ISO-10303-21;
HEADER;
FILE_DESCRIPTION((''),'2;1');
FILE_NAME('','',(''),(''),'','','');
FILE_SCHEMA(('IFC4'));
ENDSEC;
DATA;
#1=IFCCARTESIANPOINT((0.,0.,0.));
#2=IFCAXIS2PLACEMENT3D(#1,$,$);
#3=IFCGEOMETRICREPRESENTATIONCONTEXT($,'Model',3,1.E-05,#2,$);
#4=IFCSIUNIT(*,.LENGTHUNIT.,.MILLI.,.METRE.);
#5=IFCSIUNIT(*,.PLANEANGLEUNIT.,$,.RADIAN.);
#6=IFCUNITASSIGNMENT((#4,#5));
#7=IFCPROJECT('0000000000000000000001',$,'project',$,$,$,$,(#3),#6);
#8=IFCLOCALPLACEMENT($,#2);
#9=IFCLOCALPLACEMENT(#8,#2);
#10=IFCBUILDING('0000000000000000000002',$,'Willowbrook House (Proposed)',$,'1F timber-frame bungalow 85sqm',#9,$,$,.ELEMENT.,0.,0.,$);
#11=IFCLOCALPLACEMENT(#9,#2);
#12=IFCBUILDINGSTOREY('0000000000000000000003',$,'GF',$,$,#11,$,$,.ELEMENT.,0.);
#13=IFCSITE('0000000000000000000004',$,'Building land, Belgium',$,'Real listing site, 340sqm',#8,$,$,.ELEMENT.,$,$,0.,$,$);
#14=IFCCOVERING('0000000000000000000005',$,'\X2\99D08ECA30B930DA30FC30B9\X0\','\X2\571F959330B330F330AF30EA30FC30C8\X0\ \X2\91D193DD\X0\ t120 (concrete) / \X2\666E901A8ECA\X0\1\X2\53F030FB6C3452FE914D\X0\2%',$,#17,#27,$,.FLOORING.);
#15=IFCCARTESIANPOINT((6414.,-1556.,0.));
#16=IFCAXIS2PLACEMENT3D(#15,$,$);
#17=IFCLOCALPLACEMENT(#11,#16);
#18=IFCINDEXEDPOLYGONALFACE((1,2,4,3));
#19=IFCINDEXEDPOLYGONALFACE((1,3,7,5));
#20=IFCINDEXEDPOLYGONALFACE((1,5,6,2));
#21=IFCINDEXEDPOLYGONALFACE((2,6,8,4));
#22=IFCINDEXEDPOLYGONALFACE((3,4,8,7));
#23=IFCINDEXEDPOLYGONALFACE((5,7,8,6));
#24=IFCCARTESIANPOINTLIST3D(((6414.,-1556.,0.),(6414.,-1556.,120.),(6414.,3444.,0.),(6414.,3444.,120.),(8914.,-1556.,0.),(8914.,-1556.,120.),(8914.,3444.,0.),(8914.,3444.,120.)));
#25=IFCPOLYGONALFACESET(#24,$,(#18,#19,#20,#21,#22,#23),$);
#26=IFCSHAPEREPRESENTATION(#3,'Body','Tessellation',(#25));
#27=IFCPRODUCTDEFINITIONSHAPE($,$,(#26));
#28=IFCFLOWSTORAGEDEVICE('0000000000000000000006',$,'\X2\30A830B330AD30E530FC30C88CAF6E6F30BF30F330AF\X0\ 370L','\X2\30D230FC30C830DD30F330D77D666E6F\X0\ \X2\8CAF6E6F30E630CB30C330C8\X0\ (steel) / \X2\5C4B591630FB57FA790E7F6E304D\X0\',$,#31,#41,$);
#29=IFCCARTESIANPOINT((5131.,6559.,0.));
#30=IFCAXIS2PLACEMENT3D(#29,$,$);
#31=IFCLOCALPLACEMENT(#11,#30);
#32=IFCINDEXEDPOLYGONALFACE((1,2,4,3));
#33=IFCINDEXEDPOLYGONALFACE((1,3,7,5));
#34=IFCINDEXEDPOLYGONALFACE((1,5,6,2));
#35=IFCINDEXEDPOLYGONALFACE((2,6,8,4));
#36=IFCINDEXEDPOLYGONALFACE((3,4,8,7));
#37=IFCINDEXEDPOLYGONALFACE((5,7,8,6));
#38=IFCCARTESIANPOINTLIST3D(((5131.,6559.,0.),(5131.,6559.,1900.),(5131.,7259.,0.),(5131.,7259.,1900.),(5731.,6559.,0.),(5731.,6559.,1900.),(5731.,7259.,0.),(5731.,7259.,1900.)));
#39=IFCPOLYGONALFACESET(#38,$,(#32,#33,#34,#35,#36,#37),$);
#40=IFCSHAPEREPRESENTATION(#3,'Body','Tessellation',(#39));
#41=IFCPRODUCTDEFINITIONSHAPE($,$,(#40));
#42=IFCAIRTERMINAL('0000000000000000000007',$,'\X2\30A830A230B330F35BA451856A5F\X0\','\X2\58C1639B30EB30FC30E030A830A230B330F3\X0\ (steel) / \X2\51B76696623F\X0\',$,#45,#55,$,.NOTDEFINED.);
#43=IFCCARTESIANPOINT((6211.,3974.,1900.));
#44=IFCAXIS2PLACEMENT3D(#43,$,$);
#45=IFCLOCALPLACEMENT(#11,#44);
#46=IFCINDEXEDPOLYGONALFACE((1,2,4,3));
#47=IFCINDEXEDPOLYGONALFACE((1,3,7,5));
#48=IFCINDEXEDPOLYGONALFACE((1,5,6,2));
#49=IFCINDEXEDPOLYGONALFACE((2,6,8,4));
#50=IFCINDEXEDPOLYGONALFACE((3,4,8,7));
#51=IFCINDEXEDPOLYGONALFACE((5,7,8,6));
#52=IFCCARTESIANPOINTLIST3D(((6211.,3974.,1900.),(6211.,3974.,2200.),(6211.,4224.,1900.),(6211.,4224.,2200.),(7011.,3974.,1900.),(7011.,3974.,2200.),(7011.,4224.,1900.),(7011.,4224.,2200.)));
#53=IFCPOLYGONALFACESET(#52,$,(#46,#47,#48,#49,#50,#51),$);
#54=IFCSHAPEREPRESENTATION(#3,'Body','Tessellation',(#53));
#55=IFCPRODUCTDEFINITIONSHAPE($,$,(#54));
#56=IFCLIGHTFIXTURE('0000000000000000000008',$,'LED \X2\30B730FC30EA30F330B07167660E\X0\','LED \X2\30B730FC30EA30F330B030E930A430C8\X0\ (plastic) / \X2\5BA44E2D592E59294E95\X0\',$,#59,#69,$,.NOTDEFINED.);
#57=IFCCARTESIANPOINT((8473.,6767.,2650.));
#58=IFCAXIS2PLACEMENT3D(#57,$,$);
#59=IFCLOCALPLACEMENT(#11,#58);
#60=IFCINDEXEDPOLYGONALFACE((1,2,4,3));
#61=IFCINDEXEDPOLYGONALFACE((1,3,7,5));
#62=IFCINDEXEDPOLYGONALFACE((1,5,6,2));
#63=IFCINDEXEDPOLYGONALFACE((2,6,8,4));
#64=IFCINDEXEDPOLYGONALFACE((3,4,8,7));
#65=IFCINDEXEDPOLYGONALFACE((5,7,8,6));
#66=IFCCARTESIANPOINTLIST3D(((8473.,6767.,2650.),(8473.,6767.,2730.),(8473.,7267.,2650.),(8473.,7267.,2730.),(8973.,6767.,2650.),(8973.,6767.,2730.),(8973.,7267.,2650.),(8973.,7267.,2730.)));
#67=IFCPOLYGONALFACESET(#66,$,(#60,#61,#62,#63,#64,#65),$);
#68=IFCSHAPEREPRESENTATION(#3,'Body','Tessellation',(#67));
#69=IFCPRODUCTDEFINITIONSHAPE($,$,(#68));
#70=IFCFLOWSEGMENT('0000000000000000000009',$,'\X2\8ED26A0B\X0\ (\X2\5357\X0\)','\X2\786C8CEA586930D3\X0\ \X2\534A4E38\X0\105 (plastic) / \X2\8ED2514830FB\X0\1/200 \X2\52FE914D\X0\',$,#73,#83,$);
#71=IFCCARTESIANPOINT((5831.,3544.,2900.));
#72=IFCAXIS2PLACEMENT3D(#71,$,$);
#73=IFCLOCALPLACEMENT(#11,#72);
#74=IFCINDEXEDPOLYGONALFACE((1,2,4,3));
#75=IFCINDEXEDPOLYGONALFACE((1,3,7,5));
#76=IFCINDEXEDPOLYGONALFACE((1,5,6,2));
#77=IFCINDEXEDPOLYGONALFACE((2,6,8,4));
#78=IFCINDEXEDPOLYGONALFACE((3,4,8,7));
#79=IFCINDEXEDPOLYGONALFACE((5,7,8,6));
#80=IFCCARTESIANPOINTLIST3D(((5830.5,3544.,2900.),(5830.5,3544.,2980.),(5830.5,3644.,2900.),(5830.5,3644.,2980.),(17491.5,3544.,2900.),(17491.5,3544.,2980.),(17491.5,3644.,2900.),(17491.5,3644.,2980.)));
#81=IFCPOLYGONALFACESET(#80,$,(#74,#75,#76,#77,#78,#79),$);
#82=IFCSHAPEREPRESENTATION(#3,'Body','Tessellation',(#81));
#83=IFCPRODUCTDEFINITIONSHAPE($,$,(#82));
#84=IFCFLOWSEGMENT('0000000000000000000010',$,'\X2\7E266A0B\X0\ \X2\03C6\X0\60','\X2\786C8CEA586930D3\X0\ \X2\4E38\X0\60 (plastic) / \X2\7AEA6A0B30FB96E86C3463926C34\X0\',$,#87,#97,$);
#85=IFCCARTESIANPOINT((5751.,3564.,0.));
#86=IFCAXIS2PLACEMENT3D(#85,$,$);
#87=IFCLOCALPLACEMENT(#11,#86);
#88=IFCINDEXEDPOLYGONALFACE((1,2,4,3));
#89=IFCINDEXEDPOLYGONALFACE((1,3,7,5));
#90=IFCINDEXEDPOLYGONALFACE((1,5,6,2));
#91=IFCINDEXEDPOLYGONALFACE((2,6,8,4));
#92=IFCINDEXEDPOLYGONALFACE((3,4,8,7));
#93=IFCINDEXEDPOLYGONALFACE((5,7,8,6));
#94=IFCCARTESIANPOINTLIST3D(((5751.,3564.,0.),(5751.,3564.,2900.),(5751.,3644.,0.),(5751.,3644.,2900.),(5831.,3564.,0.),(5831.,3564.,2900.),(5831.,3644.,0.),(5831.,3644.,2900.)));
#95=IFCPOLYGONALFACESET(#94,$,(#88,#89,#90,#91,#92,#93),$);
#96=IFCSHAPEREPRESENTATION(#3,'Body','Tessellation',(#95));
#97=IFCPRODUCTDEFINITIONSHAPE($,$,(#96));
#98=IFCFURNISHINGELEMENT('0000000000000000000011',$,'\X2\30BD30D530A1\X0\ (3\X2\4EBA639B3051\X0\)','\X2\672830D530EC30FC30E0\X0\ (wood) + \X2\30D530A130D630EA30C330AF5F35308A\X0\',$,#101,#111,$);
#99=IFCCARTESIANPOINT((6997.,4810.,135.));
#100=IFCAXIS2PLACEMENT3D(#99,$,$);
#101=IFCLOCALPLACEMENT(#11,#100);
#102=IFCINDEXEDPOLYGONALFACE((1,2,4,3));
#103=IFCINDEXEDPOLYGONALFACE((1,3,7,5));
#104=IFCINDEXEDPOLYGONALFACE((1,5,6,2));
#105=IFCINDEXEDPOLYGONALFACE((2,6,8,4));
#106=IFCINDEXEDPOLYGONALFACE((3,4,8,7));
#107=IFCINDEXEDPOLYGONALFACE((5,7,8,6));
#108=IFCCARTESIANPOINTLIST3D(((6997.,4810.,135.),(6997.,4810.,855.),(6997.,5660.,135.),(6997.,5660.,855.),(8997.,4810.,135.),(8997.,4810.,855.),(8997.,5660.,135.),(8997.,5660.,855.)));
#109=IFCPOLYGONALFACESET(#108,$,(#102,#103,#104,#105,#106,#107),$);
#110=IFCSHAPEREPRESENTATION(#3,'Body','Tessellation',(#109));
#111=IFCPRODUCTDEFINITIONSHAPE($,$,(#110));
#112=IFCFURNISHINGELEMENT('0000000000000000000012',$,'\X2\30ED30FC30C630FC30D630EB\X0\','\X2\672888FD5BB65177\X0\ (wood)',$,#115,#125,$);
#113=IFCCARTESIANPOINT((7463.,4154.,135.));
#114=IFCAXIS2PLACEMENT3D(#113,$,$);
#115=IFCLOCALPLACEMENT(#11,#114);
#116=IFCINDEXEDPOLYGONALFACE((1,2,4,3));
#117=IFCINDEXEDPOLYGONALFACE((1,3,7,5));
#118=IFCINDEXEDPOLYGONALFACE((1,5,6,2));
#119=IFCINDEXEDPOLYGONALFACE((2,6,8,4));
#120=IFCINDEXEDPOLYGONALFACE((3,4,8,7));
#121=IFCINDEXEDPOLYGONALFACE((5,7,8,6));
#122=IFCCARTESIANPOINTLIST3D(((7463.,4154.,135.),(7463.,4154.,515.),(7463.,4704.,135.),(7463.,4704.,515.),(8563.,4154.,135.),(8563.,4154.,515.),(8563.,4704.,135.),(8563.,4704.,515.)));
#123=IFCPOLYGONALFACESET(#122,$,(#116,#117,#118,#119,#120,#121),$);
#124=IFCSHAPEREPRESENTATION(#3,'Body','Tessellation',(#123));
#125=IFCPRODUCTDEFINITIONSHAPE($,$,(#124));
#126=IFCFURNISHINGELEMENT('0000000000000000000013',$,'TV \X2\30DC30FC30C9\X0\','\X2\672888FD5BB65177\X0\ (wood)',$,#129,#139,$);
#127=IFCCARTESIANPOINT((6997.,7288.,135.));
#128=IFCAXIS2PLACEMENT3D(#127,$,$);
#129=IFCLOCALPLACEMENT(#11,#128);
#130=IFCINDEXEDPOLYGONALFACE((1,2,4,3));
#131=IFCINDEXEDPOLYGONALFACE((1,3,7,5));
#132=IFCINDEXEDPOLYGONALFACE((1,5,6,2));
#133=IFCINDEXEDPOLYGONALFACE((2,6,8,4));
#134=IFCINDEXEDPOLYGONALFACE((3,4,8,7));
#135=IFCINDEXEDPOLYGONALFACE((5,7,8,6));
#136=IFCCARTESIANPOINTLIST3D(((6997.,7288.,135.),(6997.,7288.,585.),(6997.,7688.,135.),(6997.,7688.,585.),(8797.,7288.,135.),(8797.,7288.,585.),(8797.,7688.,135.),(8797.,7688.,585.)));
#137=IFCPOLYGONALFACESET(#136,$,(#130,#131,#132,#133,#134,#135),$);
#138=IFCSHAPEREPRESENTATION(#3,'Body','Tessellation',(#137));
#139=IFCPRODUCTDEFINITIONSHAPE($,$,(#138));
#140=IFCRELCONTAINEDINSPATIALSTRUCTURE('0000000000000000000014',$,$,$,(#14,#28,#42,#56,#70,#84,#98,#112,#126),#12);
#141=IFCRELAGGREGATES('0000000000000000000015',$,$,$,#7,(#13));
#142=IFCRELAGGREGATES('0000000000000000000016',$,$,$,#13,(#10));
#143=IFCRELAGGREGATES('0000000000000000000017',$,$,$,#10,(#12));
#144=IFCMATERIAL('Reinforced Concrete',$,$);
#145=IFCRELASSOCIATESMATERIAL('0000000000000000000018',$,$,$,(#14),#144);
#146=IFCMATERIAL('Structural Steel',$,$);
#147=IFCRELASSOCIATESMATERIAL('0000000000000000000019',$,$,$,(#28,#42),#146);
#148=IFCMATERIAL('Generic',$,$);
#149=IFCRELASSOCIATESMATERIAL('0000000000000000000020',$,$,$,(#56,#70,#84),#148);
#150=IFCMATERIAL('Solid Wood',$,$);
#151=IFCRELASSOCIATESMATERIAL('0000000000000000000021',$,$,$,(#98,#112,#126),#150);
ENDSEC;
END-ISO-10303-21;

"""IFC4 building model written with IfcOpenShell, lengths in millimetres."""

from ifc_helpers import new_model, si_unit, frame, frame_2d, origin, place, context, project, spatial, rectangle, extrude, material, element, save


model = new_model("IFC4")

# Units and contexts
model_context = context("Model", 3, precision=1e-05, world=origin())
ifc_project = project(units=[si_unit("LENGTHUNIT", "METRE", prefix="MILLI"), si_unit("PLANEANGLEUNIT", "RADIAN")], contexts=[model_context])

# Site, building, storey
site_placement = place(None, origin())
site = spatial("IfcSite", under=ifc_project, at=site_placement, Name="Building land, Belgium", ObjectType="Real listing site, 340sqm", CompositionType="ELEMENT", RefElevation=0.0)
building_placement = place(site_placement, origin())
building = spatial("IfcBuilding", under=site, at=building_placement, Name="Willowbrook House (Proposed)", ObjectType="1F timber-frame bungalow 85sqm", CompositionType="ELEMENT", ElevationOfRefHeight=0.0, ElevationOfTerrain=0.0)
storey_placement = place(building_placement, origin())
storey = spatial("IfcBuildingStorey", under=building, at=storey_placement, Name="GF", CompositionType="ELEMENT", Elevation=0.0)

# Shared definitions
ifc_material_1 = material(Name="Solid Wood")

# Shared definitions
ifc_material_2 = material(Name="Reinforced Concrete")

# Shared definitions
ifc_material_3 = material(Name="Structural Steel")

# Covering
ifc_material_4 = material(Name="Generic")
covering_1_placement = place(storey_placement, frame((6414.0, -1556.0, 0.0)))
element("IfcCovering", 1, at=covering_1_placement, inside=storey, material=ifc_material_2, Name="駐車スペース", Description="土間コンクリート 金鏝 t120 (concrete) / 普通車1台・水勾配2%", PredefinedType="FLOORING", context=model_context, shape_type="SweptSolid", body=[
    extrude(rectangle(XDim=2500.0, YDim=5000.0, at=frame_2d((1250.0, 2500.0))), frame((6414.0, -1556.0, 0.0)), (0.0, 0.0, 1.0), 120.0),
])

# Flow storage device
flow_storage_device_placement = place(storey_placement, frame((5131.0, 6559.0, 0.0)))
element("IfcFlowStorageDevice", 2, at=flow_storage_device_placement, inside=storey, material=ifc_material_3, Name="エコキュート貯湯タンク 370L", Description="ヒートポンプ給湯 貯湯ユニット (steel) / 屋外・基礎置き", context=model_context, shape_type="SweptSolid", body=[
    extrude(rectangle(XDim=600.0, YDim=700.0, at=frame_2d((300.0, 350.0))), frame((5131.0, 6559.0, 0.0)), (0.0, 0.0, 1.0), 1900.0),
])

# Air terminal
air_terminal_placement = place(storey_placement, frame((6211.0, 3974.0, 1900.0)))
element("IfcAirTerminal", 3, at=air_terminal_placement, inside=storey, material=ifc_material_3, Name="エアコン室内機", Description="壁掛ルームエアコン (steel) / 冷暖房", PredefinedType="NOTDEFINED", context=model_context, shape_type="SweptSolid", body=[
    extrude(rectangle(XDim=800.0, YDim=250.0, at=frame_2d((400.0, 125.0))), frame((6211.0, 3974.0, 1900.0)), (0.0, 0.0, 1.0), 300.0),
])

# Light fixture
light_fixture_placement = place(storey_placement, frame((8473.0, 6767.0, 2650.0)))
element("IfcLightFixture", 4, at=light_fixture_placement, inside=storey, material=ifc_material_4, Name="LED シーリング照明", Description="LED シーリングライト (plastic) / 室中央天井", PredefinedType="NOTDEFINED", context=model_context, shape_type="SweptSolid", body=[
    extrude(rectangle(XDim=500.0, YDim=500.0, at=frame_2d((250.0, 250.0))), frame((8473.0, 6767.0, 2650.0)), (0.0, 0.0, 1.0), 80.0),
])

# Flow segments
flow_segment_1_placement = place(storey_placement, frame((5831.0, 3544.0, 2900.0)))
element("IfcFlowSegment", 5, at=flow_segment_1_placement, inside=storey, material=ifc_material_4, Name="軒樋 (南)", Description="硬質塩ビ 半丸105 (plastic) / 軒先・1/200 勾配", context=model_context, shape_type="SweptSolid", body=[
    extrude(rectangle(XDim=11661.0, YDim=100.0, at=frame_2d((5830.0, 50.0))), frame((5831.0, 3544.0, 2900.0)), (0.0, 0.0, 1.0), 80.0),
])
flow_segment_2_placement = place(storey_placement, frame((5751.0, 3564.0, 0.0)))
element("IfcFlowSegment", 6, at=flow_segment_2_placement, inside=storey, material=ifc_material_4, Name="縦樋 φ60", Description="硬質塩ビ 丸60 (plastic) / 竪樋・雨水排水", context=model_context, shape_type="SweptSolid", body=[
    extrude(rectangle(XDim=80.0, YDim=80.0, at=frame_2d((40.0, 40.0))), frame((5751.0, 3564.0, 0.0)), (0.0, 0.0, 1.0), 2900.0),
])

# Furnishing elements
furnishing_1_placement = place(storey_placement, frame((6997.0, 4810.0, 135.0)))
element("IfcFurnishingElement", 7, at=furnishing_1_placement, inside=storey, material=ifc_material_1, Name="ソファ (3人掛け)", Description="木フレーム (wood) + ファブリック張り", context=model_context, shape_type="SweptSolid", body=[
    extrude(rectangle(XDim=2000.0, YDim=850.0, at=frame_2d((1000.0, 425.0))), frame((6997.0, 4810.0, 135.0)), (0.0, 0.0, 1.0), 720.0),
])
furnishing_2_placement = place(storey_placement, frame((7463.0, 4154.0, 135.0)))
element("IfcFurnishingElement", 8, at=furnishing_2_placement, inside=storey, material=ifc_material_1, Name="ローテーブル", Description="木製家具 (wood)", context=model_context, shape_type="SweptSolid", body=[
    extrude(rectangle(XDim=1100.0, YDim=550.0, at=frame_2d((550.0, 275.0))), frame((7463.0, 4154.0, 135.0)), (0.0, 0.0, 1.0), 380.0),
])
furnishing_3_placement = place(storey_placement, frame((6997.0, 7288.0, 135.0)))
element("IfcFurnishingElement", 9, at=furnishing_3_placement, inside=storey, material=ifc_material_1, Name="TV ボード", Description="木製家具 (wood)", context=model_context, shape_type="SweptSolid", body=[
    extrude(rectangle(XDim=1800.0, YDim=400.0, at=frame_2d((900.0, 200.0))), frame((6997.0, 7288.0, 135.0)), (0.0, 0.0, 1.0), 450.0),
])

save(model, "model.ifc")
